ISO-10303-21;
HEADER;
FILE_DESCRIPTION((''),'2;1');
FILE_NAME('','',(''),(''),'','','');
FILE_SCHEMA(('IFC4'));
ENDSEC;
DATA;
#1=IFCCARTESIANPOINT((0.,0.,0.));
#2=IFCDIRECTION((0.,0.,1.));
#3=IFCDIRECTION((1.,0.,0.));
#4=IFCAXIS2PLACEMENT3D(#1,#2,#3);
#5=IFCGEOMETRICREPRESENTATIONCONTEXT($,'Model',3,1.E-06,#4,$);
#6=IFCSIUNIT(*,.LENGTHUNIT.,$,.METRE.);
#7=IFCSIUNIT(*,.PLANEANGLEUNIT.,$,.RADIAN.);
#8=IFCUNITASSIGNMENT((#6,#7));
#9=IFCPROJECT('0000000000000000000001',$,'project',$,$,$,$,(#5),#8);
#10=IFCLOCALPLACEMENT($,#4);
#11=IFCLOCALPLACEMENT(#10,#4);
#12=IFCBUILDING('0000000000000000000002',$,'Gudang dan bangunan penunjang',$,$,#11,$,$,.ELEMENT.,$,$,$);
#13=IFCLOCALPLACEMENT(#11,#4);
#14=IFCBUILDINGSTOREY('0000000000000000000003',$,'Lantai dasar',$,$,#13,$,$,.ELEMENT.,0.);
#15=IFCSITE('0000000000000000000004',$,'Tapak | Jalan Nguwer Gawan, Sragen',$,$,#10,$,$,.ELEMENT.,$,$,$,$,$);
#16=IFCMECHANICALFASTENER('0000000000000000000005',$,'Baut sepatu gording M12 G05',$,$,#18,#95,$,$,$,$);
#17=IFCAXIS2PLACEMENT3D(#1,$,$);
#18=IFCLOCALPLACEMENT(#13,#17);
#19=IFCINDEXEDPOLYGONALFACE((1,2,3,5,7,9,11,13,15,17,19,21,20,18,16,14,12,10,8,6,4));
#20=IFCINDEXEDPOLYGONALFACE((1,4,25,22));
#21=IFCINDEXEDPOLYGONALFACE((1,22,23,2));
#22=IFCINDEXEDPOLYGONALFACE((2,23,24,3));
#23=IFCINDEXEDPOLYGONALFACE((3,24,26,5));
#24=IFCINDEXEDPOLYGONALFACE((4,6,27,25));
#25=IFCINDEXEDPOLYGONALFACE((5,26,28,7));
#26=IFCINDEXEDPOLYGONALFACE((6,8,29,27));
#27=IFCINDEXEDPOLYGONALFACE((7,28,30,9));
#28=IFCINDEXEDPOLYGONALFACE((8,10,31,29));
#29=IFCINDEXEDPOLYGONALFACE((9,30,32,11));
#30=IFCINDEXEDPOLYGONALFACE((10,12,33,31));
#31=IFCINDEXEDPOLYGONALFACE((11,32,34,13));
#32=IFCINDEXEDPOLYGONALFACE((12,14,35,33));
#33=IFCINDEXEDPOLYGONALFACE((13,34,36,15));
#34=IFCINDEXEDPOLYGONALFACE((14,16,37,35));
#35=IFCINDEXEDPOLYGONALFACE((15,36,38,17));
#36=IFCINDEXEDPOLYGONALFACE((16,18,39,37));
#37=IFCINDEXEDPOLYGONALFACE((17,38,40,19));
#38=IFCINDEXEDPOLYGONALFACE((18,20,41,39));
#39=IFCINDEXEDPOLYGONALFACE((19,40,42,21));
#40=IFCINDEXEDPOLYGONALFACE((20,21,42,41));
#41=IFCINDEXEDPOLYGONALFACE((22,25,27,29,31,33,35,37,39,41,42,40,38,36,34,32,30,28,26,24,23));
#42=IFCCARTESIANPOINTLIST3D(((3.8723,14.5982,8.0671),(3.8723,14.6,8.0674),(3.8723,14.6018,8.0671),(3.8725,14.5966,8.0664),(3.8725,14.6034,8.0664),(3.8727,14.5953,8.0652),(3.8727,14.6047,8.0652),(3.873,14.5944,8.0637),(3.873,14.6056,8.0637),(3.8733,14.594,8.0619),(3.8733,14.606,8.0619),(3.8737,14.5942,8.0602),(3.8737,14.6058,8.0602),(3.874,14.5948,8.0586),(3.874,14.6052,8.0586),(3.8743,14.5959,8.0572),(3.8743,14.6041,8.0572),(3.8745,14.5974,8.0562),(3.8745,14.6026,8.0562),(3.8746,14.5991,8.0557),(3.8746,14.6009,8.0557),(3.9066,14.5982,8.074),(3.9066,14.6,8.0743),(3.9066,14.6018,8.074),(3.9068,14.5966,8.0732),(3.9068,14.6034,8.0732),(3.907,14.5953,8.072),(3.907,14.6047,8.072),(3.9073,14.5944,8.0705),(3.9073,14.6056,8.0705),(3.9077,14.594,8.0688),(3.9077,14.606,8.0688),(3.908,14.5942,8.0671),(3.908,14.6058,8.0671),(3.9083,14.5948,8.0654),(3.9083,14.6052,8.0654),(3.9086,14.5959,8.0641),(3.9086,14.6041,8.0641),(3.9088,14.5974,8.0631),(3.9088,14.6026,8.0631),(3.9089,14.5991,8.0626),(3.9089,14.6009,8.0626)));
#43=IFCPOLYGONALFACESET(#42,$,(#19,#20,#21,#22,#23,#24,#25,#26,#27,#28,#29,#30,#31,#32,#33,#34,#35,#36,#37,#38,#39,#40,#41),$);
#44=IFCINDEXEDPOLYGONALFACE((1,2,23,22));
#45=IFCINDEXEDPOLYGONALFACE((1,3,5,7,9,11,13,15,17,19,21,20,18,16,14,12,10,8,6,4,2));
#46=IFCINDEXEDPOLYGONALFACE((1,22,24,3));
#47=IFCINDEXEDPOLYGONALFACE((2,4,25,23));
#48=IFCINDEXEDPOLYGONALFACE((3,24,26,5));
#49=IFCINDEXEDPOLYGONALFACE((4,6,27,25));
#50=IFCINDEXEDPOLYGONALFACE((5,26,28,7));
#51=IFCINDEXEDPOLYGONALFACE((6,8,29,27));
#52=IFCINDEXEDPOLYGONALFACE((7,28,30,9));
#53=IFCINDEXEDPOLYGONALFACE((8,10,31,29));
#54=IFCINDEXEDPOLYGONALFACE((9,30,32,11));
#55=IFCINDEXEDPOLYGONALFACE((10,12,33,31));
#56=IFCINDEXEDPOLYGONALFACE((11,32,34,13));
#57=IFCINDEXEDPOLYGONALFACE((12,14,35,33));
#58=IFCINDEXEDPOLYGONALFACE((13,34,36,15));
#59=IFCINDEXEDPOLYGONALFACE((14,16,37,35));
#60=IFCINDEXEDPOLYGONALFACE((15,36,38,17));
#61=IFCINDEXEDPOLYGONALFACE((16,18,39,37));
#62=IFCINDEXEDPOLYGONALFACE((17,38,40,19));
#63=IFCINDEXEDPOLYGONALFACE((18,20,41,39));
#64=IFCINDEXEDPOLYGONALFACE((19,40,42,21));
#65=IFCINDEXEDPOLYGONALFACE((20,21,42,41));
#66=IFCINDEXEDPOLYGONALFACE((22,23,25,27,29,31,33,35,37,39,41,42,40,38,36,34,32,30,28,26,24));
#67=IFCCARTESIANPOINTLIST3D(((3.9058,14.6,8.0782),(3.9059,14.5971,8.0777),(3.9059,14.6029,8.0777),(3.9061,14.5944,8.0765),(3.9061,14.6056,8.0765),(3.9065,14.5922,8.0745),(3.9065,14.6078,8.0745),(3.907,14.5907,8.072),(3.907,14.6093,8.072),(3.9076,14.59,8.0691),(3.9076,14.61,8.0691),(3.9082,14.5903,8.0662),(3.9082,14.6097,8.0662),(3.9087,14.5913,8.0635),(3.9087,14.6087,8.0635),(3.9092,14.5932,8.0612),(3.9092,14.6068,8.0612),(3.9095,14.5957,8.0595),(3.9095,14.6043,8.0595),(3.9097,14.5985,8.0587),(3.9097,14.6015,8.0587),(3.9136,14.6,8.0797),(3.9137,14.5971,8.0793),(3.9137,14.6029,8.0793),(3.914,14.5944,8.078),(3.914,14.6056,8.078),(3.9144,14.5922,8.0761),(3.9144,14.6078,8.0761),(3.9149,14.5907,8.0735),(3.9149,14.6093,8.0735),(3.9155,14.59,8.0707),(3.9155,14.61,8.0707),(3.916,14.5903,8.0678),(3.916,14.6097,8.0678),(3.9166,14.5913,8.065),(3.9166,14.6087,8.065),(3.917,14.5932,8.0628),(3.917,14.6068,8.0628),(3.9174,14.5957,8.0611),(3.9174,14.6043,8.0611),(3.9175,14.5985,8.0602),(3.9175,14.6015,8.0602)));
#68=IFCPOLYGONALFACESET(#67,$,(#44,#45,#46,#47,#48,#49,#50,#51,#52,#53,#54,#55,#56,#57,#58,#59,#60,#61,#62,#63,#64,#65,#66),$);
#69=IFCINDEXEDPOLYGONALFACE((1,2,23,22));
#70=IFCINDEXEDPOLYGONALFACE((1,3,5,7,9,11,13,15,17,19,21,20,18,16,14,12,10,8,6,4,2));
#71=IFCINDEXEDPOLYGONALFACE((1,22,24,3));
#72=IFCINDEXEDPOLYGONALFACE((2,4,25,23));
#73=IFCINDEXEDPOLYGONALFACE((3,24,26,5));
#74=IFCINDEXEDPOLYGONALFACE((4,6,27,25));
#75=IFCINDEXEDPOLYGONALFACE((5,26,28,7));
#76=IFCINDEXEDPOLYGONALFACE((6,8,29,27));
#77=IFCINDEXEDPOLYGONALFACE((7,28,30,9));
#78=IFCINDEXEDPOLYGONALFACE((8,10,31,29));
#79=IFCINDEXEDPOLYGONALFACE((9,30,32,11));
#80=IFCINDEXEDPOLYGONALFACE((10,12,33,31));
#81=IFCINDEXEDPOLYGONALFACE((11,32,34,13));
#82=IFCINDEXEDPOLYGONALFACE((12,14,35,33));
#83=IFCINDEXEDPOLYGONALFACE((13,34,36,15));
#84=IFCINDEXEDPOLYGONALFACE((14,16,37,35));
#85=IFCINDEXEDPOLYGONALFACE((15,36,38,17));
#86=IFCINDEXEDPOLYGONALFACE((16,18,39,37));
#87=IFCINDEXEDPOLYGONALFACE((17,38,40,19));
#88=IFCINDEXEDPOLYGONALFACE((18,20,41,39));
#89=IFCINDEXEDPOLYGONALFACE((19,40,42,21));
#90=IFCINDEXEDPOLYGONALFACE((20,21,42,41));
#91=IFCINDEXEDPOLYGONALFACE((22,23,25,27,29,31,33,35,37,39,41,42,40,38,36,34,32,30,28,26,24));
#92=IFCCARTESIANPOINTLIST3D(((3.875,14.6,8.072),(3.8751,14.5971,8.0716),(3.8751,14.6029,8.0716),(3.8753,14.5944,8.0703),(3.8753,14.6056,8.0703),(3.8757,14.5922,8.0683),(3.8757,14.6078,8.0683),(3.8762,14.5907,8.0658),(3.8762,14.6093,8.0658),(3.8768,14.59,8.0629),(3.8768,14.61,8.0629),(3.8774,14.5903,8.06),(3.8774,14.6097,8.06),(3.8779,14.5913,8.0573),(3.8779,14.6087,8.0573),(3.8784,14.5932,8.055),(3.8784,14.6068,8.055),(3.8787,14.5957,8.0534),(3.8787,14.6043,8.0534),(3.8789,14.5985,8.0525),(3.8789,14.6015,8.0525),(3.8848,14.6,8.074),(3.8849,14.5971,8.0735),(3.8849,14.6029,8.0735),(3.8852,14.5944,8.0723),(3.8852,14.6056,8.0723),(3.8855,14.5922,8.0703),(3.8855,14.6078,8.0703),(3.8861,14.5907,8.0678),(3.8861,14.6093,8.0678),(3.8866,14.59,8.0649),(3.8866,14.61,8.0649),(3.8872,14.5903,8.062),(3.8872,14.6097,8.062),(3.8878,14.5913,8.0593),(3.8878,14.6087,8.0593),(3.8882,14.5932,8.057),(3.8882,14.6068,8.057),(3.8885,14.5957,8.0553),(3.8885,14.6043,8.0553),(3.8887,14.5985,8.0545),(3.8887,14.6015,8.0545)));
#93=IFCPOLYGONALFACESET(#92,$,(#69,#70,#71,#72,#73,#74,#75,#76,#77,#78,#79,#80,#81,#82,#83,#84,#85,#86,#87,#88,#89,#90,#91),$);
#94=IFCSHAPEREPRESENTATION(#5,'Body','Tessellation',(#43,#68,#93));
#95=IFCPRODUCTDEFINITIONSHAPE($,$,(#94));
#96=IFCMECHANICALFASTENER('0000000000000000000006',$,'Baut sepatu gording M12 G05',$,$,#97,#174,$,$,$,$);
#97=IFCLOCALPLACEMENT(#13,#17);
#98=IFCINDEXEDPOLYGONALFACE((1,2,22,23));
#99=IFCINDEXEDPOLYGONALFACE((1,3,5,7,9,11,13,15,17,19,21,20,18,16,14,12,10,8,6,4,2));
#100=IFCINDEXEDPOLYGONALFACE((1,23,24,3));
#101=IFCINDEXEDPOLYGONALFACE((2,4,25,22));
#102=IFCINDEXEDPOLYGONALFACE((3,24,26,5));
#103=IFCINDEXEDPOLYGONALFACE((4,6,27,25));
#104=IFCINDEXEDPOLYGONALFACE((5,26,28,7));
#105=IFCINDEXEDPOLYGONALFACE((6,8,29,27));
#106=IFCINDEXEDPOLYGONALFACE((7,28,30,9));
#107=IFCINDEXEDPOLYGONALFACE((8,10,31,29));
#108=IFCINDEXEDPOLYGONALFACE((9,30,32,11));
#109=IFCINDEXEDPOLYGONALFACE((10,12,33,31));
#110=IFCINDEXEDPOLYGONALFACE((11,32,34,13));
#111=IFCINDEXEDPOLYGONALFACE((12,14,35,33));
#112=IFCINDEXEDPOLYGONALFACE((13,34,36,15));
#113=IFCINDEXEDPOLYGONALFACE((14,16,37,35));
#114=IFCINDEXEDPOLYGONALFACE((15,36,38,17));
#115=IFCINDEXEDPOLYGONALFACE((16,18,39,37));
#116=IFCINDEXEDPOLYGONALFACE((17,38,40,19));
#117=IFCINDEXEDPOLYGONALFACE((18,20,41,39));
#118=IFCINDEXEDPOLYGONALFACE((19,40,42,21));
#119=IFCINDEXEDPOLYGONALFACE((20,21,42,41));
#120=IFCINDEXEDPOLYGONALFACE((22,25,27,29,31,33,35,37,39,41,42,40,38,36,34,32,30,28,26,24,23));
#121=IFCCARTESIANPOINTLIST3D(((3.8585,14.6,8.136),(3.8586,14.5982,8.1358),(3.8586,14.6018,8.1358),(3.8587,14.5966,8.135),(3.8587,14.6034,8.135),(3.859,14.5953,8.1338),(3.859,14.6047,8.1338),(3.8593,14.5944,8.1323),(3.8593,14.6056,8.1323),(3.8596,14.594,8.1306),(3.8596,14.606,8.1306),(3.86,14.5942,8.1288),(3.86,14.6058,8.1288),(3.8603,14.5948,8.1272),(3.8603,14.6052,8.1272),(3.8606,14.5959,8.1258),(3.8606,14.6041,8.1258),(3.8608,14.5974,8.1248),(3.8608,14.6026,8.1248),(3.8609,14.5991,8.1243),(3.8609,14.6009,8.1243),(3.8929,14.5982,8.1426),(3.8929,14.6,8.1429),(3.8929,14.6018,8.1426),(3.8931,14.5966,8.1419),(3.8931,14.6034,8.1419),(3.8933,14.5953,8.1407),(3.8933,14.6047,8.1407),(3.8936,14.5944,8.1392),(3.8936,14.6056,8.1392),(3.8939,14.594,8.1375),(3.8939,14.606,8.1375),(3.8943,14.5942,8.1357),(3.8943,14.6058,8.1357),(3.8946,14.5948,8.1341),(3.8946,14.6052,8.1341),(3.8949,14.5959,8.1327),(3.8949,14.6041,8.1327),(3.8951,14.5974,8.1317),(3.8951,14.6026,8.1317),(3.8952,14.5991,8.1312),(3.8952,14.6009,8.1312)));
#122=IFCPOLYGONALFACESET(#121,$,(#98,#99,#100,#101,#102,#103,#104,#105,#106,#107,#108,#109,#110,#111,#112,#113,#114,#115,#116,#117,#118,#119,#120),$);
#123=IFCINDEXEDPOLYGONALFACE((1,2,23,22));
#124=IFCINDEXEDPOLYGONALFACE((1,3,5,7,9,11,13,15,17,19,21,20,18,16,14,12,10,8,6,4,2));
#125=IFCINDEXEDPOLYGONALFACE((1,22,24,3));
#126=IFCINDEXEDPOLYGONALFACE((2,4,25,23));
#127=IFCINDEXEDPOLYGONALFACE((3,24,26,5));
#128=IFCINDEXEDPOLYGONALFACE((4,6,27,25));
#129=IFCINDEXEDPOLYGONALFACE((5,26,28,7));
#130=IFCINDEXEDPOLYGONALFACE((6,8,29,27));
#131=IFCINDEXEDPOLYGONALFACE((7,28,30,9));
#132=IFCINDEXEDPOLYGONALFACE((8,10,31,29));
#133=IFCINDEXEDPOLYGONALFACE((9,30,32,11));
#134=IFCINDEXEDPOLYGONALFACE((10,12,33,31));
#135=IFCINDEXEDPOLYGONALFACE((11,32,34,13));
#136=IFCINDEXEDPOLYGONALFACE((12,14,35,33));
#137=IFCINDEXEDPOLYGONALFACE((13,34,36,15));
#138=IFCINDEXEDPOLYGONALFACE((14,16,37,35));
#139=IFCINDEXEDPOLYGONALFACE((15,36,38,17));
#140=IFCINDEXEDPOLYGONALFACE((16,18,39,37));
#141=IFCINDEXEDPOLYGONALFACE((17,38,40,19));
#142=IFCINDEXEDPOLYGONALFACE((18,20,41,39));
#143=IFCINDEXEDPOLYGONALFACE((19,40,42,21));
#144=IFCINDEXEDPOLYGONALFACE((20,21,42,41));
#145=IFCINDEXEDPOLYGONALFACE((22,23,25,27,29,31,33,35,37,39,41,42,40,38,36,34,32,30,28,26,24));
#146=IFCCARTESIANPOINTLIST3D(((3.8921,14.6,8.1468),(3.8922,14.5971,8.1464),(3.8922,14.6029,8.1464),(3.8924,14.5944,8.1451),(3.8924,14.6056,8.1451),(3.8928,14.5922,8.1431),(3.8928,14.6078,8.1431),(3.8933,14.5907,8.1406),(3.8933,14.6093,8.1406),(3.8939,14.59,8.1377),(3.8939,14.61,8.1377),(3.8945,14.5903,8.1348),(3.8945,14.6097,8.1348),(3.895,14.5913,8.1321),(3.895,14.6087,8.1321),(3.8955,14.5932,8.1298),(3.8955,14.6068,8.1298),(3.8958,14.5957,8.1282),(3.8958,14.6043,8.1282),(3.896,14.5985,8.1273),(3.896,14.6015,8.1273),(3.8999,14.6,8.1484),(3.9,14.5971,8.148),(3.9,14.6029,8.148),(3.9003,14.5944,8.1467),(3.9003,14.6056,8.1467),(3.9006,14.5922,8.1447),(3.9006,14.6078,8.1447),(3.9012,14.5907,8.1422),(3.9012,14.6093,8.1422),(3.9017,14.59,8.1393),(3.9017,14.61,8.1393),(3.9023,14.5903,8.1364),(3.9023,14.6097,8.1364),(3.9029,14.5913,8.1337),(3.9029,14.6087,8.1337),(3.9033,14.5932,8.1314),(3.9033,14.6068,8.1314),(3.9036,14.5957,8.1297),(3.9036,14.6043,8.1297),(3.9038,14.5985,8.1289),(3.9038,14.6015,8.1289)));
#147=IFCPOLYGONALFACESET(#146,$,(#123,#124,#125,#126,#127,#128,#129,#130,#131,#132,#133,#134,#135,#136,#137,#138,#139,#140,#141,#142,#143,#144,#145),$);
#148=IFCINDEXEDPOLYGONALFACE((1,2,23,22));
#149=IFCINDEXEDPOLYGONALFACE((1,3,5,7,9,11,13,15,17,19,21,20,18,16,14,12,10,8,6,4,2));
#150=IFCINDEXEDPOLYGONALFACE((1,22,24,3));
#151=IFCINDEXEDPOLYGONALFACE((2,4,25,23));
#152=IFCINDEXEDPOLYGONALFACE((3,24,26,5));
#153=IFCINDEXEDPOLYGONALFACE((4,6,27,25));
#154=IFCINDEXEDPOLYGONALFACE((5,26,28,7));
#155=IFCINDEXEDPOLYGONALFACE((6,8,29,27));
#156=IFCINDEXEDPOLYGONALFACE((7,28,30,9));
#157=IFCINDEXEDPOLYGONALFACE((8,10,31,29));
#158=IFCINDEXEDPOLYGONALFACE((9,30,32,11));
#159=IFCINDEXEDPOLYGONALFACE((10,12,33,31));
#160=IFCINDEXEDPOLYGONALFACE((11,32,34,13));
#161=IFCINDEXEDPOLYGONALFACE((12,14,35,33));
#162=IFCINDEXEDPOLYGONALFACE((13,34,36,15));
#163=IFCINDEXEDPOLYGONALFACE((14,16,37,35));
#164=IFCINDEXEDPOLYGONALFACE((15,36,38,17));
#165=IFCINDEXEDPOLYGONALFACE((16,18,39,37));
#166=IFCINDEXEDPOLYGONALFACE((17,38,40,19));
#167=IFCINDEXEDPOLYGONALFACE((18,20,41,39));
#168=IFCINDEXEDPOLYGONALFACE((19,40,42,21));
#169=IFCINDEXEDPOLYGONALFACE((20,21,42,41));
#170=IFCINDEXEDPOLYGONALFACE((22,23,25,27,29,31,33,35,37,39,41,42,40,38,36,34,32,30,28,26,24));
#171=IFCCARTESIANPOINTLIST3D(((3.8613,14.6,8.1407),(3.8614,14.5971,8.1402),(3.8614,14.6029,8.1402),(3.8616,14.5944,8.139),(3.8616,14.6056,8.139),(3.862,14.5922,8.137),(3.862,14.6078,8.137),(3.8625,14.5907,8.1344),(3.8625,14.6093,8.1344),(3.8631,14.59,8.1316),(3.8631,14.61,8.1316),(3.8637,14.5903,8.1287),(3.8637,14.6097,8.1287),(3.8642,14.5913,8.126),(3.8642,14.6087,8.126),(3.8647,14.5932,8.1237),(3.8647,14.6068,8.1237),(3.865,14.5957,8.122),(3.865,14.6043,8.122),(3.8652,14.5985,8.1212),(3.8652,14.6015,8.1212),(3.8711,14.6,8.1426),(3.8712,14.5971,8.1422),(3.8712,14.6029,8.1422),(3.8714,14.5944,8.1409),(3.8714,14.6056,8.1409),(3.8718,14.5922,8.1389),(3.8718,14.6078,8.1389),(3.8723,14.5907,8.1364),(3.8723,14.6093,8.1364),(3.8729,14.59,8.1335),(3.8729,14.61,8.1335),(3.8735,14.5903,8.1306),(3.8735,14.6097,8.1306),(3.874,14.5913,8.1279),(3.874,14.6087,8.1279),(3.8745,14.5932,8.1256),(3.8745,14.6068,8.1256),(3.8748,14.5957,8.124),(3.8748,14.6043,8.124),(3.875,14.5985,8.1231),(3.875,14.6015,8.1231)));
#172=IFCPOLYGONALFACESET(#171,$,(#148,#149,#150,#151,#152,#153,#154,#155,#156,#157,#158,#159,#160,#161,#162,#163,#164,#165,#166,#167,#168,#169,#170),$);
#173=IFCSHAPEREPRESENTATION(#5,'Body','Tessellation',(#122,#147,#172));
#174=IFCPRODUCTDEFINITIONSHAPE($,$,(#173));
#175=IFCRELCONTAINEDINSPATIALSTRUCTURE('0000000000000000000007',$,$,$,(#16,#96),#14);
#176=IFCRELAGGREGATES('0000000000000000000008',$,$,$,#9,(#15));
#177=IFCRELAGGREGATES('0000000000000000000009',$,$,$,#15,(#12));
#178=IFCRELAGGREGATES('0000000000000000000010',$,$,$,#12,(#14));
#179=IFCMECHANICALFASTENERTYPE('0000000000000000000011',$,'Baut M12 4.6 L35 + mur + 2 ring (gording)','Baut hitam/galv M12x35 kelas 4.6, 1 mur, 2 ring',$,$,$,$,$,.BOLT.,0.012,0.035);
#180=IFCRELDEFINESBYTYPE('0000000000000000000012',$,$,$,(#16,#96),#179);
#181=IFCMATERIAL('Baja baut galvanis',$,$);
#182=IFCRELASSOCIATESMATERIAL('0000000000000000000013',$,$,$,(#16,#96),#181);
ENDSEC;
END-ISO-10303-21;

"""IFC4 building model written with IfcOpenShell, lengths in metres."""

from ifc_helpers import new_model, si_unit, frame, origin_with_axes, place, context, project, spatial, circle, extrude, source, transform, mapped, material, type_object, type_shapes, element, save


model = new_model("IFC4")

# Units and contexts
model_context = context("Model", 3, precision=1e-06, world=origin_with_axes())
ifc_project = project(units=[si_unit("LENGTHUNIT", "METRE"), si_unit("PLANEANGLEUNIT", "RADIAN")], contexts=[model_context])

# Site, building, storey
site_placement = place(None, origin_with_axes())
site = spatial("IfcSite", under=ifc_project, at=site_placement, Name="Tapak | Jalan Nguwer Gawan, Sragen", CompositionType="ELEMENT")
building_placement = place(site_placement, origin_with_axes())
building = spatial("IfcBuilding", under=site, at=building_placement, Name="Gudang dan bangunan penunjang", CompositionType="ELEMENT")
storey_placement = place(building_placement, origin_with_axes())
storey = spatial("IfcBuildingStorey", under=building, at=storey_placement, Name="Lantai dasar", CompositionType="ELEMENT", Elevation=0.0)

# Shared definitions
placement = place(None, origin_with_axes())

# Mechanical fasteners
ifc_material_1 = material(Name="Baja baut galvanis")
mechanical_fastener_type = type_object("IfcMechanicalFastenerType", Name="Baut M12 4.6 L35 + mur + 2 ring (gording)", Description="Baut hitam/galv M12x35 kelas 4.6, 1 mur, 2 ring", NominalDiameter=0.012, NominalLength=0.035, PredefinedType="BOLT")
shared_shape = source(origin_with_axes(), model_context, "Body", "SweptSolid", [
    extrude(circle(Radius=0.006), origin_with_axes(), (0.0, 0.0, 1.0), 0.035),
    extrude(circle(Radius=0.01), frame((0.0, 0.0, -0.008), z_axis=(0.0, 0.0, 1.0), x_axis=(1.0, 0.0, 0.0)), (0.0, 0.0, 1.0), 0.008),
    extrude(circle(Radius=0.01), frame((0.0, 0.0, 0.0214), z_axis=(0.0, 0.0, 1.0), x_axis=(1.0, 0.0, 0.0)), (0.0, 0.0, 1.0), 0.01),
])
type_shapes(mechanical_fastener_type, [shared_shape])
element("IfcMechanicalFastener", 1, at=placement, inside=storey, type_object=mechanical_fastener_type, material=ifc_material_1, Name="Baut sepatu gording M12 G05", context=model_context, shape_type="MappedRepresentation", body=[
    mapped(shared_shape, transform((3.9078, 14.6, 8.0684), x_axis=(-0.196116, 0.0, 0.980581), y_axis=(0.0, 1.0, 0.0), z_axis=(-0.980581, 0.0, -0.196116), scale=1.0)),
])
element("IfcMechanicalFastener", 2, at=placement, inside=storey, type_object=mechanical_fastener_type, material=ifc_material_1, Name="Baut sepatu gording M12 G05", context=model_context, shape_type="MappedRepresentation", body=[
    mapped(shared_shape, transform((3.894, 14.6, 8.137), x_axis=(-0.196116, 0.0, 0.980581), y_axis=(0.0, 1.0, 0.0), z_axis=(-0.980581, 0.0, -0.196116), scale=1.0)),
])

save(model, "model.ifc")
